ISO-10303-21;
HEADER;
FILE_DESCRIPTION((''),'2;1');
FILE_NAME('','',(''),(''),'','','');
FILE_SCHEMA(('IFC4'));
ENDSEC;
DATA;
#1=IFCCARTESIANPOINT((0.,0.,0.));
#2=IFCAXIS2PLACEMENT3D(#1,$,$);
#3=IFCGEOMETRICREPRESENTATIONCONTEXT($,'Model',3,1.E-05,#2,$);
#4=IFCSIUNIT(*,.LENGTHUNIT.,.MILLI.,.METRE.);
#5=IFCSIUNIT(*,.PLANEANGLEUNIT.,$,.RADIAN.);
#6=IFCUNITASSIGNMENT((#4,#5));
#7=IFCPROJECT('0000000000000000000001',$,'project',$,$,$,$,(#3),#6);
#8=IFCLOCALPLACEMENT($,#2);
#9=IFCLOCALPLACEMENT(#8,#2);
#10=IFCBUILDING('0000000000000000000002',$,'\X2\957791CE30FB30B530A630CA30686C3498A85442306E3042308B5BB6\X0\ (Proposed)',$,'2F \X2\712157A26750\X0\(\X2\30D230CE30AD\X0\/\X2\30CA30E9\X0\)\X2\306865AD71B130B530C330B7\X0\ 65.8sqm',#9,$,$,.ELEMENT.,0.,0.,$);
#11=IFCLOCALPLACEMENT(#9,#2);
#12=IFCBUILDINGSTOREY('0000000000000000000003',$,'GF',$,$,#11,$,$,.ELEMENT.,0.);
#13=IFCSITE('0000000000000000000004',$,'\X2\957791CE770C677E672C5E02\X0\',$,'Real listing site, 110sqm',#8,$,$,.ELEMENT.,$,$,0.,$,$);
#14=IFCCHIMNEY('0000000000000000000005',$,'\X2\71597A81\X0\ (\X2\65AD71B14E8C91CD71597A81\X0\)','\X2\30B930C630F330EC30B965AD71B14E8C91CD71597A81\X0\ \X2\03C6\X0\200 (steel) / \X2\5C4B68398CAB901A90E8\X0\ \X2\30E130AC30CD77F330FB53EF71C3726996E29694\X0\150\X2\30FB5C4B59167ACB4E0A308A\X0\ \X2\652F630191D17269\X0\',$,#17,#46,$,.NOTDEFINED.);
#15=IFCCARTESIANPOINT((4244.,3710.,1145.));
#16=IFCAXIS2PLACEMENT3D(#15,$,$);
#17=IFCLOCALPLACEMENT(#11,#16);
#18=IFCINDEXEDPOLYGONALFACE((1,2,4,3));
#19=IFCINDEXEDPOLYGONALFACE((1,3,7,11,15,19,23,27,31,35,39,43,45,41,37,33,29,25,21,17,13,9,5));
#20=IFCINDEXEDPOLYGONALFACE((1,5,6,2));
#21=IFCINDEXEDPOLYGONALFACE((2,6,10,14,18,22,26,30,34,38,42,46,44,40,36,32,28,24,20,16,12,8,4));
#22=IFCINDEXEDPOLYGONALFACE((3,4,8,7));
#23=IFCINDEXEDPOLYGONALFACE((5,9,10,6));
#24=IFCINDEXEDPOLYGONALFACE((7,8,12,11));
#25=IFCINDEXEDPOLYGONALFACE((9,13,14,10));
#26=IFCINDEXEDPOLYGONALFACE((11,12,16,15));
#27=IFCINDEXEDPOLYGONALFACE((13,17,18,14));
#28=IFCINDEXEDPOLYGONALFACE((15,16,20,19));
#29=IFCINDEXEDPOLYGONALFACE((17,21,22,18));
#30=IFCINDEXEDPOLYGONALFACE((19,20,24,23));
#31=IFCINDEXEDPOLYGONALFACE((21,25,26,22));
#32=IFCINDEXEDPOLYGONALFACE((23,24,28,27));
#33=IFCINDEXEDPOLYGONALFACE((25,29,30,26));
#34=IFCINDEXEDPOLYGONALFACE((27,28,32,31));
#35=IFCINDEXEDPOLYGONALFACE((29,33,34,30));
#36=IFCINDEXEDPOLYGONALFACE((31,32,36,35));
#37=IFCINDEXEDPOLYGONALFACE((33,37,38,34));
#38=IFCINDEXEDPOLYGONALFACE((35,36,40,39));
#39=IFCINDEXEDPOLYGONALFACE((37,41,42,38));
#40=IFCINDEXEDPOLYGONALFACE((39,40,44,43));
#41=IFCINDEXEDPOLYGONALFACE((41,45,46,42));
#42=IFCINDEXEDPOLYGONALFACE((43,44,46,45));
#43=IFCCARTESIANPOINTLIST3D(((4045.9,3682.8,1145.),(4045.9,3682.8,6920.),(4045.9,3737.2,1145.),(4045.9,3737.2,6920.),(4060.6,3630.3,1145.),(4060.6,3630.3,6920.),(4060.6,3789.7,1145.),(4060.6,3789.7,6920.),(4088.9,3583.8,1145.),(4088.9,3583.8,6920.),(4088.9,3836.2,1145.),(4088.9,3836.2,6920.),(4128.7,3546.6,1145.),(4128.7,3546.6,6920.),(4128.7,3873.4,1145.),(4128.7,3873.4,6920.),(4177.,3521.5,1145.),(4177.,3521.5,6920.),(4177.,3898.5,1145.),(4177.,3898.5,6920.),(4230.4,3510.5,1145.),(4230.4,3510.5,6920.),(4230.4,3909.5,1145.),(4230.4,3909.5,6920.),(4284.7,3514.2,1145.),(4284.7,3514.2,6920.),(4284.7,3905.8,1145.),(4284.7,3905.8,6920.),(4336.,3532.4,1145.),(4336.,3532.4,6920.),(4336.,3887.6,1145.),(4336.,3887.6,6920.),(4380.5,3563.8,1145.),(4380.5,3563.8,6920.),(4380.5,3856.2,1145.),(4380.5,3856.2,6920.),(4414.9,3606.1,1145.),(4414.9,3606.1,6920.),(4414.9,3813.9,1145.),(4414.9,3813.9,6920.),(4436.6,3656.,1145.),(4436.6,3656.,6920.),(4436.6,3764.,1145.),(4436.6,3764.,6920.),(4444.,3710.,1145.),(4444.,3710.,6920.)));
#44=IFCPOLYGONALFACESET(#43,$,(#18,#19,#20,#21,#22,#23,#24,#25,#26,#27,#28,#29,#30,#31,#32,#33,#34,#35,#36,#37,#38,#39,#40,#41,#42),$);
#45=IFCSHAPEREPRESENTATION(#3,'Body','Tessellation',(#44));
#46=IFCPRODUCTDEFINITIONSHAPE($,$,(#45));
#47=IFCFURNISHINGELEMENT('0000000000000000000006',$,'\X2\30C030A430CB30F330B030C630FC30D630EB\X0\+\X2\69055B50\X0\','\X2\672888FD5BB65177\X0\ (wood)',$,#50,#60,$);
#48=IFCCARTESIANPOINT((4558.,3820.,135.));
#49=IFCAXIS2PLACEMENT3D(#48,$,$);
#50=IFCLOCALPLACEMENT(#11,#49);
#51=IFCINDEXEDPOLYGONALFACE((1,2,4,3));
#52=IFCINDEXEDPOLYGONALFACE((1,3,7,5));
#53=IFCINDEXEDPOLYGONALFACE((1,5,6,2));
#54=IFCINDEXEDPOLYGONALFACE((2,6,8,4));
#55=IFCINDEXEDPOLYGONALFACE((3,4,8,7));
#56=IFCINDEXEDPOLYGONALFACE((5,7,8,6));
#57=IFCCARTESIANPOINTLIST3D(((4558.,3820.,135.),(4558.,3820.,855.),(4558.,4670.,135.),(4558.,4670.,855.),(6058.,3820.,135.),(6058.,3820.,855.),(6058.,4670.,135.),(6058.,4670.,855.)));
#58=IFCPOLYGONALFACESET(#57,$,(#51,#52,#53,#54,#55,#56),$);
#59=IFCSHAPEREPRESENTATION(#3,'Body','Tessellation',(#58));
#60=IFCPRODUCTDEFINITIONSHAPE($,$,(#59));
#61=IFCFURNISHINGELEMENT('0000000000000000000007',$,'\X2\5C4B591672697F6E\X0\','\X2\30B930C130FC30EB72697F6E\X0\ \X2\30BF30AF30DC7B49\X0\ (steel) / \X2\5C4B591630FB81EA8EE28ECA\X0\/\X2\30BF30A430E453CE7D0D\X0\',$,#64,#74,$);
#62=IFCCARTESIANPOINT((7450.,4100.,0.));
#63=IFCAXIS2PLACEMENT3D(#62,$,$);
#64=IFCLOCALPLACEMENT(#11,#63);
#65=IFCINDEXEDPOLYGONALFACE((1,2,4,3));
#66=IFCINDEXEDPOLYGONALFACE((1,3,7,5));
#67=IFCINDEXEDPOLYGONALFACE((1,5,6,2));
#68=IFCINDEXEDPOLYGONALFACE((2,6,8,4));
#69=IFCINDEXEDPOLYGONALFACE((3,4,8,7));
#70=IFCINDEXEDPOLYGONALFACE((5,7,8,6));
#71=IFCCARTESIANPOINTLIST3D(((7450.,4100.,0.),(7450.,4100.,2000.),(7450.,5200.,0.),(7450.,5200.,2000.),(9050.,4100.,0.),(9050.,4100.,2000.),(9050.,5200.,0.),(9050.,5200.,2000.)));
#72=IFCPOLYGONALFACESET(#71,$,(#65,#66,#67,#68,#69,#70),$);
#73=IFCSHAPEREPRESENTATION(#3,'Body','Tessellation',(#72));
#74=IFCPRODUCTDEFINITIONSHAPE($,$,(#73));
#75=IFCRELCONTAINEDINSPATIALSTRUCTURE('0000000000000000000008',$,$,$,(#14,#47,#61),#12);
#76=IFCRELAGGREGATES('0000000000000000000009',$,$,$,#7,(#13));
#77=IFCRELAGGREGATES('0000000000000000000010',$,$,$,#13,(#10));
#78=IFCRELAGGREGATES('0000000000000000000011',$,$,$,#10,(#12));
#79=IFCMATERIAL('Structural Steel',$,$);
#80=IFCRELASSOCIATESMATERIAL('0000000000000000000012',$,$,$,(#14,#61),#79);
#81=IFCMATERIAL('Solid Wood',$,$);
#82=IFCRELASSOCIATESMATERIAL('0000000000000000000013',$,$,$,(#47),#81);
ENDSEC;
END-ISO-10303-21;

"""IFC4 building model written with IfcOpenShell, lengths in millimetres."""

from ifc_helpers import new_model, si_unit, frame, frame_2d, origin, origin_2d, place, context, project, spatial, rectangle, circle, extrude, material, element, save


model = new_model("IFC4")

# Units and contexts
model_context = context("Model", 3, precision=1e-05, world=origin())
ifc_project = project(units=[si_unit("LENGTHUNIT", "METRE", prefix="MILLI"), si_unit("PLANEANGLEUNIT", "RADIAN")], contexts=[model_context])

# Site, building, storey
site_placement = place(None, origin())
site = spatial("IfcSite", under=ifc_project, at=site_placement, Name="長野県松本市", ObjectType="Real listing site, 110sqm", CompositionType="ELEMENT", RefElevation=0.0)
building_placement = place(site_placement, origin())
building = spatial("IfcBuilding", under=site, at=building_placement, Name="長野・サウナと水風呂のある家 (Proposed)", ObjectType="2F 無垢材(ヒノキ/ナラ)と断熱サッシ 65.8sqm", CompositionType="ELEMENT", ElevationOfRefHeight=0.0, ElevationOfTerrain=0.0)
storey_placement = place(building_placement, origin())
storey = spatial("IfcBuildingStorey", under=building, at=storey_placement, Name="GF", CompositionType="ELEMENT", Elevation=0.0)

# Shared definitions
ifc_material_1 = material(Name="Solid Wood")

# Shared definitions
ifc_material_2 = material(Name="Structural Steel")

# Chimney
chimney_placement = place(storey_placement, frame((4244.0, 3710.0, 1145.0)))
element("IfcChimney", 1, at=chimney_placement, inside=storey, material=ifc_material_2, Name="煙突 (断熱二重煙突)", Description="ステンレス断熱二重煙突 φ200 (steel) / 屋根貫通部 メガネ石・可燃物離隔150・屋外立上り 支持金物", PredefinedType="NOTDEFINED", context=model_context, shape_type="SweptSolid", body=[
    extrude(circle(Radius=200.0, at=origin_2d()), frame((4244.0, 3710.0, 1145.0)), (0.0, 0.0, 1.0), 5775.0),
])

# Furnishing elements
furnishing_1_placement = place(storey_placement, frame((4558.0, 3820.0, 135.0)))
element("IfcFurnishingElement", 2, at=furnishing_1_placement, inside=storey, material=ifc_material_1, Name="ダイニングテーブル+椅子", Description="木製家具 (wood)", context=model_context, shape_type="SweptSolid", body=[
    extrude(rectangle(XDim=1500.0, YDim=850.0, at=frame_2d((750.0, 425.0))), frame((4558.0, 3820.0, 135.0)), (0.0, 0.0, 1.0), 720.0),
])
furnishing_2_placement = place(storey_placement, frame((7450.0, 4100.0, 0.0)))
element("IfcFurnishingElement", 3, at=furnishing_2_placement, inside=storey, material=ifc_material_2, Name="屋外物置", Description="スチール物置 タクボ等 (steel) / 屋外・自転車/タイヤ収納", context=model_context, shape_type="SweptSolid", body=[
    extrude(rectangle(XDim=1600.0, YDim=1100.0, at=frame_2d((800.0, 550.0))), frame((7450.0, 4100.0, 0.0)), (0.0, 0.0, 1.0), 2000.0),
])

save(model, "model.ifc")
